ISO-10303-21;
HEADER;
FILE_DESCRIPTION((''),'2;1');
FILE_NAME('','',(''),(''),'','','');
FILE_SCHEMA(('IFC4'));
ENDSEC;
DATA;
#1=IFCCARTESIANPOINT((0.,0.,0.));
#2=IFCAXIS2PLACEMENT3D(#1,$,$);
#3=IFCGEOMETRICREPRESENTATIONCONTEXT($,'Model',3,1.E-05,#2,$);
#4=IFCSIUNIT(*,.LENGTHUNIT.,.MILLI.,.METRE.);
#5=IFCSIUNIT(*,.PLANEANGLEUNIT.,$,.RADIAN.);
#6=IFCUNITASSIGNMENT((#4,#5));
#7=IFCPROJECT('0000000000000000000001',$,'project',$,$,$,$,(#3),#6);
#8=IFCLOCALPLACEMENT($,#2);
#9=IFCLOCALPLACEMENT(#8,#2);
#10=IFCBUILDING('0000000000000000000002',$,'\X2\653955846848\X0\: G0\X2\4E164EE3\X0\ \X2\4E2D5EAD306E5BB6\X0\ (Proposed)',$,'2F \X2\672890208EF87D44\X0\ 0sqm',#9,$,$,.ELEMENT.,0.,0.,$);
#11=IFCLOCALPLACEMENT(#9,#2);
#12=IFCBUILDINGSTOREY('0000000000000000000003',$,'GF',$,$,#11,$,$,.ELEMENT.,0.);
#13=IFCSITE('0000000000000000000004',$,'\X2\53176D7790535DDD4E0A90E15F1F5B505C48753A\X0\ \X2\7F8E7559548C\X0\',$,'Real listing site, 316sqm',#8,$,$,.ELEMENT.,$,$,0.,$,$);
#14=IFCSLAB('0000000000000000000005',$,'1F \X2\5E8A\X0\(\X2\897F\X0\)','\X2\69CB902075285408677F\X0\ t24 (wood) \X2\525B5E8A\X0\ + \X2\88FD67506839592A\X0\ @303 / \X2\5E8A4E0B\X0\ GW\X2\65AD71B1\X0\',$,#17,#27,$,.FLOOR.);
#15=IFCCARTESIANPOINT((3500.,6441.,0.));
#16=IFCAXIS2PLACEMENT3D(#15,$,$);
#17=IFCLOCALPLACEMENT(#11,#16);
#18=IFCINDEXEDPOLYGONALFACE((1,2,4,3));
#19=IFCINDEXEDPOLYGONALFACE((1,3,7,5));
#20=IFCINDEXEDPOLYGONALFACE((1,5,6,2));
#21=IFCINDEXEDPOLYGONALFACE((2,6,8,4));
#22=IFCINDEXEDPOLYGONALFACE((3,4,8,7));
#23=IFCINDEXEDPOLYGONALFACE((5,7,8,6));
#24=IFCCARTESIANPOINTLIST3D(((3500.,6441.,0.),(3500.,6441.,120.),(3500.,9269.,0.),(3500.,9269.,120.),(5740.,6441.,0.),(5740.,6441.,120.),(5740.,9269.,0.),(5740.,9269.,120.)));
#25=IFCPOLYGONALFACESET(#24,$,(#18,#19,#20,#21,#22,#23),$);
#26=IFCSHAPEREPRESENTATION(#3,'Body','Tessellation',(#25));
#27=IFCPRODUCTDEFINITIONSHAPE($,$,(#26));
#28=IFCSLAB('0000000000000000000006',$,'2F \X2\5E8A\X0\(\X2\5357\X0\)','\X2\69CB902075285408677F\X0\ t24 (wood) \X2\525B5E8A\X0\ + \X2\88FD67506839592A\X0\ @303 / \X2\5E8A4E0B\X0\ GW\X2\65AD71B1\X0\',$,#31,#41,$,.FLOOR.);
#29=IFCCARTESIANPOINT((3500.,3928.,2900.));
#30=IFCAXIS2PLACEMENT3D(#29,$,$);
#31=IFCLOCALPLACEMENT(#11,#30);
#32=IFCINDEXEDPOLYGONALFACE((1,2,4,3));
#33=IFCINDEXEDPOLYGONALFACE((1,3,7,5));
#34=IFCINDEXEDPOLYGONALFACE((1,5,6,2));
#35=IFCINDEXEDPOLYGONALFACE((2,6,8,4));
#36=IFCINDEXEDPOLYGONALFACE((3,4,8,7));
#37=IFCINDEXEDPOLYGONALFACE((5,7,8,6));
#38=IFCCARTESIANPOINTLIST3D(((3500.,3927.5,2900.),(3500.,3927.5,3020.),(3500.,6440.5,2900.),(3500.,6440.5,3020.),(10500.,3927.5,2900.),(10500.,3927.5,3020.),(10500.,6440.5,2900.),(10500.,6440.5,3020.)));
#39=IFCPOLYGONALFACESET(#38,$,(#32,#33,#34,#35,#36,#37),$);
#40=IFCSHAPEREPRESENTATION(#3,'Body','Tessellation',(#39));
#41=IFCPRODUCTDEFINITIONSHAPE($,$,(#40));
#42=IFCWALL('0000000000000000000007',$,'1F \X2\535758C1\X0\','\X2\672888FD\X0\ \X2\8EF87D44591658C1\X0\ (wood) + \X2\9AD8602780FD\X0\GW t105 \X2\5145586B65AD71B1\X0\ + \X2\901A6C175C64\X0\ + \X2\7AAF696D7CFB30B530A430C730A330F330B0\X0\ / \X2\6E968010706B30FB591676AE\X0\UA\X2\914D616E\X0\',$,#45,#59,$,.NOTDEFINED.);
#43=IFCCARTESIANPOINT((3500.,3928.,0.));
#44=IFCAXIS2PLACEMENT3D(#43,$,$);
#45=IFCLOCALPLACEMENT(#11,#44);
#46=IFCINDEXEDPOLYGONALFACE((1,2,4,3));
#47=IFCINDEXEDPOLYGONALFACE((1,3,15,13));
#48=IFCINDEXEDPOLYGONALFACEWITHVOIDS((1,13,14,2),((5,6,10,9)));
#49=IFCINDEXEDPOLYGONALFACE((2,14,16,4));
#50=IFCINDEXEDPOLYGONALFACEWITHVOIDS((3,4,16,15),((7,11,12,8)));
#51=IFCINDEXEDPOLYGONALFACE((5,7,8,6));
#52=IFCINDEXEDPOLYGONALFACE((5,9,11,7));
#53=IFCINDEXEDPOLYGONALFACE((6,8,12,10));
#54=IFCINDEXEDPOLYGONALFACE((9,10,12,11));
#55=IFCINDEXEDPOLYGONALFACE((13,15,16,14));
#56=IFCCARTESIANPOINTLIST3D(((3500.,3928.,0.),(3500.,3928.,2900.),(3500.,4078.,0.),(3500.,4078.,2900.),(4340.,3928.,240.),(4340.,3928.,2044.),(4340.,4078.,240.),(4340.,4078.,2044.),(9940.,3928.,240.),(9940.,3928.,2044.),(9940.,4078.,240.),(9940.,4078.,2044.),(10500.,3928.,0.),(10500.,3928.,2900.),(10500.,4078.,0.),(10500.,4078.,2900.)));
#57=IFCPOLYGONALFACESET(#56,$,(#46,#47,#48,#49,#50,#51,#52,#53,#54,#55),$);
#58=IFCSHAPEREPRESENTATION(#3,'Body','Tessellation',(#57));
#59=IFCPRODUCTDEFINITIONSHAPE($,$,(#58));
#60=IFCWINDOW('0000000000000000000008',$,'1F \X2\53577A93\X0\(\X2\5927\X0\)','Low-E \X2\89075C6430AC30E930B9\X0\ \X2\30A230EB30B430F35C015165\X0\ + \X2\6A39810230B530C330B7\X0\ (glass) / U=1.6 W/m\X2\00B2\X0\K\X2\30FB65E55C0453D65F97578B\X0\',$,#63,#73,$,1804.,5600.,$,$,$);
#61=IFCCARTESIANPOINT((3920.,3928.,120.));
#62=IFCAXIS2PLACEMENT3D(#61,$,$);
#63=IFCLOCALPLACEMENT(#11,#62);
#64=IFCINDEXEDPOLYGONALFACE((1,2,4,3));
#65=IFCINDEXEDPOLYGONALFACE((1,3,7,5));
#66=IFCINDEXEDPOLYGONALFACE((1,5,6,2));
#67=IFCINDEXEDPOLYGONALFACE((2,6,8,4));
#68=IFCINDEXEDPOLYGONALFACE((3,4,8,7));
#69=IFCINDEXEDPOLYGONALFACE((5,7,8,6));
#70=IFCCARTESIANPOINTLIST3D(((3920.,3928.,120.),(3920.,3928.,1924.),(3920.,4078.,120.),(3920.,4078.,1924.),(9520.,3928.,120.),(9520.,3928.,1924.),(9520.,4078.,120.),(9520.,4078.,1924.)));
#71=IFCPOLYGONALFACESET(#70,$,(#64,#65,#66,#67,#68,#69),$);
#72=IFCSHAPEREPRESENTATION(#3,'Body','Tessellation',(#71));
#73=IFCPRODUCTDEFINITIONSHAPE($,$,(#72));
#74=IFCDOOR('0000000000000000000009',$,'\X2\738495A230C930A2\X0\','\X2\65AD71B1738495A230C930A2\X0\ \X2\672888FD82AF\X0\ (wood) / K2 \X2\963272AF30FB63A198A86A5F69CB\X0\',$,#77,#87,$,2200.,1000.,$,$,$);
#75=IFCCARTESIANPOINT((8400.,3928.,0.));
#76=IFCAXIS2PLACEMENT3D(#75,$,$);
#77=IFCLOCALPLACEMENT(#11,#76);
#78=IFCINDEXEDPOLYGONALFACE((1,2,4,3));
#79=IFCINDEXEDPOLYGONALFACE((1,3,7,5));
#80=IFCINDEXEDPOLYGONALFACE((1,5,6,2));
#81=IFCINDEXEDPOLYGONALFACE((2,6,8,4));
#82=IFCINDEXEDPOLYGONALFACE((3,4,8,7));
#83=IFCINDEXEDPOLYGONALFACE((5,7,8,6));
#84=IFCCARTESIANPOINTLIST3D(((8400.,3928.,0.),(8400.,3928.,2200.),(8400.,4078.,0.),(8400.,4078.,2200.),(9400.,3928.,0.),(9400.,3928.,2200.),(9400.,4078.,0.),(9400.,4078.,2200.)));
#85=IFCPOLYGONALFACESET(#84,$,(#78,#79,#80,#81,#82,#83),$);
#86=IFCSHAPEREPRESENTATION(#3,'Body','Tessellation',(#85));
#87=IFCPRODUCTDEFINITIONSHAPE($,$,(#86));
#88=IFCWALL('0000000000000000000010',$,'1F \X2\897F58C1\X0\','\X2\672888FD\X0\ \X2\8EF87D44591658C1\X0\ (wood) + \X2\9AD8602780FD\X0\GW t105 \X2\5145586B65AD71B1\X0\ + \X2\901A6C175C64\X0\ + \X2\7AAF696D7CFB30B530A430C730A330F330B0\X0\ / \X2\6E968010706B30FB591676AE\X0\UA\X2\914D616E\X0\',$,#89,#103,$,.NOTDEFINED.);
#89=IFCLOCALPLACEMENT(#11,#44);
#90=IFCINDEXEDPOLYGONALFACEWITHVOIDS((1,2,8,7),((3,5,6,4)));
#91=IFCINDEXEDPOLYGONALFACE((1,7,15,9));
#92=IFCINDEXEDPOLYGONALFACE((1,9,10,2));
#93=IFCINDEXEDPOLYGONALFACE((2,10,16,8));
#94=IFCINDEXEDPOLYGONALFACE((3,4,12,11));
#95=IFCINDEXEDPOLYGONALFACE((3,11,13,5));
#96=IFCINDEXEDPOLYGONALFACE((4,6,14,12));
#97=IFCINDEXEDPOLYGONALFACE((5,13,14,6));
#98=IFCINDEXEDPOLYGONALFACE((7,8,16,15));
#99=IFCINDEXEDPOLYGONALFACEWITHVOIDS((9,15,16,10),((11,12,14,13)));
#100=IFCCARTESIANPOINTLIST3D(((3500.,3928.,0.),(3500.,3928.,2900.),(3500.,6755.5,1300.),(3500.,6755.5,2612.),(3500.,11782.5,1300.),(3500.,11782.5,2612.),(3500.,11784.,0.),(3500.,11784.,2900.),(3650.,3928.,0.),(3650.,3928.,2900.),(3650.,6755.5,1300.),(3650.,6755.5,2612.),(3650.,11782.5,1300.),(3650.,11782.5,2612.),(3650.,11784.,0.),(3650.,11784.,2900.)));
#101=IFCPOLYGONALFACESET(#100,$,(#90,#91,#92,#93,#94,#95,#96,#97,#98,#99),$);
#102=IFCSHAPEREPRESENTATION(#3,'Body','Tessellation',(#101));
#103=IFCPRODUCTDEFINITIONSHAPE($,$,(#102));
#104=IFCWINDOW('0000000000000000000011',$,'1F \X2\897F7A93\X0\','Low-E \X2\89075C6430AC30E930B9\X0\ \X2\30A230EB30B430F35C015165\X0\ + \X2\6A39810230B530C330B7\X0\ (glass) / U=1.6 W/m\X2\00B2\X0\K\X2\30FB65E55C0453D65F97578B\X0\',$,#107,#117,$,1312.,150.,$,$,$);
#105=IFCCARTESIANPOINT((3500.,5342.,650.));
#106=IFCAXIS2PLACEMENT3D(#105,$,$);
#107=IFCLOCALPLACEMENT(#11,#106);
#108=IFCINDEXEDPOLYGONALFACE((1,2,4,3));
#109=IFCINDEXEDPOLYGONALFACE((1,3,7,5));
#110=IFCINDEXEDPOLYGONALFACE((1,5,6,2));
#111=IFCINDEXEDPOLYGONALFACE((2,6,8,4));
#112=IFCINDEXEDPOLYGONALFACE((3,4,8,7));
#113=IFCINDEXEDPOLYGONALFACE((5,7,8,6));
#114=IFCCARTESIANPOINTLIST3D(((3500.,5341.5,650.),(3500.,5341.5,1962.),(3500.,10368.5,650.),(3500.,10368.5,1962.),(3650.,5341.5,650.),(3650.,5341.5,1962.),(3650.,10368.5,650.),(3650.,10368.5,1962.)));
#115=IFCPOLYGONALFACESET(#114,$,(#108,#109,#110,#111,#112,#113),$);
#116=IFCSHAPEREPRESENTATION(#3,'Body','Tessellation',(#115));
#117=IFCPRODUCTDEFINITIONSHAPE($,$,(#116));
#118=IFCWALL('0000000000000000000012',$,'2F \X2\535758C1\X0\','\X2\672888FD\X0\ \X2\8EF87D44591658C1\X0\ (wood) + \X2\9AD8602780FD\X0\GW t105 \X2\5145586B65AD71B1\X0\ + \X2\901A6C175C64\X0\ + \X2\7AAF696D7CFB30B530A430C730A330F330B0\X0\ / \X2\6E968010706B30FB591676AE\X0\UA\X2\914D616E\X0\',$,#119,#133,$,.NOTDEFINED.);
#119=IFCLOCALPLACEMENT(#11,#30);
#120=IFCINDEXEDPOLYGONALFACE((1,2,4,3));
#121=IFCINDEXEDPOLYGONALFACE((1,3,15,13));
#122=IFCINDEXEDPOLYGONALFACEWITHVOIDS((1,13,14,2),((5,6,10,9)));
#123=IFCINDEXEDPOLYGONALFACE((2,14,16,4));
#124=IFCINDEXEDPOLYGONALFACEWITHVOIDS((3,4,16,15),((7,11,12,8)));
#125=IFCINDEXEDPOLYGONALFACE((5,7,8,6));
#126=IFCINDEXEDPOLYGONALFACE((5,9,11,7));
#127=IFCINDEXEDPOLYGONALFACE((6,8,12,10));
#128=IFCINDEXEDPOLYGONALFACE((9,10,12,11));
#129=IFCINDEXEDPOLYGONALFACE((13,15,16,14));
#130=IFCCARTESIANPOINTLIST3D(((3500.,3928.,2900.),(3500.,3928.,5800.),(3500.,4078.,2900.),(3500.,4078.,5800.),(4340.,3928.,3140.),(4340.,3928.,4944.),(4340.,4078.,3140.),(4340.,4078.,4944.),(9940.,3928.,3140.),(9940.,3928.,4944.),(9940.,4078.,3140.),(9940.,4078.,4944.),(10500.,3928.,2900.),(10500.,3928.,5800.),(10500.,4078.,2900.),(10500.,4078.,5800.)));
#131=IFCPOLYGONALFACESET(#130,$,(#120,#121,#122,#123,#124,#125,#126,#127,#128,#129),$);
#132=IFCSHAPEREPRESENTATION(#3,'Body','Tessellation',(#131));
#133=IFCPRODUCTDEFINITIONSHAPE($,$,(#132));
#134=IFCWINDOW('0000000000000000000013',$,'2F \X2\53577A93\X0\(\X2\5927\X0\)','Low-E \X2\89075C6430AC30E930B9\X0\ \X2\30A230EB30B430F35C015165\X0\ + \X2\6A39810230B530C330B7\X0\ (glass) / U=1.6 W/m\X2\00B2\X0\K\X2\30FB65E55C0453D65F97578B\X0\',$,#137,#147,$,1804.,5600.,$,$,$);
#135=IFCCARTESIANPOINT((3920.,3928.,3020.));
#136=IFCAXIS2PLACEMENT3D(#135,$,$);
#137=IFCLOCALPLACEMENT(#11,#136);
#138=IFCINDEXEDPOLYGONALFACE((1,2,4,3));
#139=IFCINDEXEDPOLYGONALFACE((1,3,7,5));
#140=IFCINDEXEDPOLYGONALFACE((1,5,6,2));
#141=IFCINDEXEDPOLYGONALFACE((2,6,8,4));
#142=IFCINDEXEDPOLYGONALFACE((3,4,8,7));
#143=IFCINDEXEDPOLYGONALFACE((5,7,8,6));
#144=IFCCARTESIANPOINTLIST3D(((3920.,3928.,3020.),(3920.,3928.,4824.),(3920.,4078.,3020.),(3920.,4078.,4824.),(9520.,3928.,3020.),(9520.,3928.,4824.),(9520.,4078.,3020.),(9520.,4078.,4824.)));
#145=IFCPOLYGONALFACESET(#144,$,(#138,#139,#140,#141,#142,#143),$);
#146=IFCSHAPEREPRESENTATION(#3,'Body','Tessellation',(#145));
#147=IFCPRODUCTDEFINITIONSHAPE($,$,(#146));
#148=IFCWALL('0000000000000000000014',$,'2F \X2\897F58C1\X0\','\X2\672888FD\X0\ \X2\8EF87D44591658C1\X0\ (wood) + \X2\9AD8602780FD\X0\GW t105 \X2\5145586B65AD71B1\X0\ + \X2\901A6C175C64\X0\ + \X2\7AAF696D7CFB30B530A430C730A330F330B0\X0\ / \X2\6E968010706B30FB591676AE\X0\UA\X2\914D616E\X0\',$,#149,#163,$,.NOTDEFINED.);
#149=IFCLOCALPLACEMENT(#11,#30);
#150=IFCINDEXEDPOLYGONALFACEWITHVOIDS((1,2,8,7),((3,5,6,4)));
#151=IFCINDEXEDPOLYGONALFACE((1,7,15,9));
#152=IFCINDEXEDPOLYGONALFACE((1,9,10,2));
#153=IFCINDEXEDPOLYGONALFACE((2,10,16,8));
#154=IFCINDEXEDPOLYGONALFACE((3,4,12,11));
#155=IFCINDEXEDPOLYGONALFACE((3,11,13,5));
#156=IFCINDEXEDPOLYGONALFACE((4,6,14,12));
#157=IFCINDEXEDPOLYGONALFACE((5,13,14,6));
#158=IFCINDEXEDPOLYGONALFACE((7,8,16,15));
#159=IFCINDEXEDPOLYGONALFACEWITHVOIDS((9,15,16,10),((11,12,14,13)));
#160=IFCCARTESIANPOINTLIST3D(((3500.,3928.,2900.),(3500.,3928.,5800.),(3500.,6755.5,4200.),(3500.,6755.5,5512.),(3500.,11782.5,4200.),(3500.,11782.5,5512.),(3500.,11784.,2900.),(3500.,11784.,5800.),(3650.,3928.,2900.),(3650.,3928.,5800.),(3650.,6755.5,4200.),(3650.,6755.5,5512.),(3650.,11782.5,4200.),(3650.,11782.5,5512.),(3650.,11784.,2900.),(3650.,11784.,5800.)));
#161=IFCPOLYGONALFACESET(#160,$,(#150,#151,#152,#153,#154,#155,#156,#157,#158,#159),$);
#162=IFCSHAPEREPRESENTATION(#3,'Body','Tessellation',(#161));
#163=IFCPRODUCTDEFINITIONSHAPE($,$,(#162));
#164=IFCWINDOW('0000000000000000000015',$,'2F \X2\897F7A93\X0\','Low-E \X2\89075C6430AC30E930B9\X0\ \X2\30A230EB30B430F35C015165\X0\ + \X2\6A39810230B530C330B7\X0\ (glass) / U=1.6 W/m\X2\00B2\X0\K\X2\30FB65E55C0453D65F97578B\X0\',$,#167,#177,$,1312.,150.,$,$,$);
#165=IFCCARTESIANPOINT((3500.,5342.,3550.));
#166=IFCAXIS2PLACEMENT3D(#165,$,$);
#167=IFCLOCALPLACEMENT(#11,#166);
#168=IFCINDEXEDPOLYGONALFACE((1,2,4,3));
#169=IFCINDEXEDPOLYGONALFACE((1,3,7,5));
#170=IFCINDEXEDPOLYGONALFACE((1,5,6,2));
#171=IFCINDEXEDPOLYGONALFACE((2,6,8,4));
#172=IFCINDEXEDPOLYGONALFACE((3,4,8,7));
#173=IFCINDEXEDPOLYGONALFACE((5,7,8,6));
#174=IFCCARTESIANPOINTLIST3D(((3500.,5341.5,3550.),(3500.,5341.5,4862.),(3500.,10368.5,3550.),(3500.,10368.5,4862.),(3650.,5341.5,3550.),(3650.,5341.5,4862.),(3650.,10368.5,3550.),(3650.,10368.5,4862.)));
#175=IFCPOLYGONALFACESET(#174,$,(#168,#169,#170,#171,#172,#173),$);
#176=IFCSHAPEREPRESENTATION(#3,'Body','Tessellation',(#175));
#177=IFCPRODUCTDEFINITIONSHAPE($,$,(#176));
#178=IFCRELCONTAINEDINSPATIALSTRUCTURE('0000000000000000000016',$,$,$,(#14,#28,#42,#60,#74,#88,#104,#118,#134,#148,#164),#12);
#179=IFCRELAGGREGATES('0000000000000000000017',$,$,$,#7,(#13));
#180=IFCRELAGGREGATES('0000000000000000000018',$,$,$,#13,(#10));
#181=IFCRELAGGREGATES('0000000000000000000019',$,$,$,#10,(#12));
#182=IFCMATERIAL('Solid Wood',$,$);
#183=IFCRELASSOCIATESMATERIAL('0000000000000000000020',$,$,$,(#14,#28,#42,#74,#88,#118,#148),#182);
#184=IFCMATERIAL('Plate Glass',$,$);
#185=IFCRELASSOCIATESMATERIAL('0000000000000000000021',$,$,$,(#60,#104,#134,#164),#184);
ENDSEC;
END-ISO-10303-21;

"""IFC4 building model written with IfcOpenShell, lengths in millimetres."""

from ifc_helpers import new_model, si_unit, frame, frame_2d, origin, place, context, project, spatial, rectangle, extrude, material, element, fill, save


model = new_model("IFC4")

# Units and contexts
model_context = context("Model", 3, precision=1e-05, world=origin())
ifc_project = project(units=[si_unit("LENGTHUNIT", "METRE", prefix="MILLI"), si_unit("PLANEANGLEUNIT", "RADIAN")], contexts=[model_context])

# Site, building, storey
site_placement = place(None, origin())
site = spatial("IfcSite", under=ifc_project, at=site_placement, Name="北海道川上郡弟子屈町 美留和", ObjectType="Real listing site, 316sqm", CompositionType="ELEMENT", RefElevation=0.0)
building_placement = place(site_placement, origin())
building = spatial("IfcBuilding", under=site, at=building_placement, Name="改善案: G0世代 中庭の家 (Proposed)", ObjectType="2F 木造軸組 0sqm", CompositionType="ELEMENT", ElevationOfRefHeight=0.0, ElevationOfTerrain=0.0)
storey_placement = place(building_placement, origin())
storey = spatial("IfcBuildingStorey", under=building, at=storey_placement, Name="GF", CompositionType="ELEMENT", Elevation=0.0)

# Slabs
ifc_material_1 = material(Name="Solid Wood")
slab_1_placement = place(storey_placement, frame((3500.0, 6441.0, 0.0)))
element("IfcSlab", 1, at=slab_1_placement, inside=storey, material=ifc_material_1, Name="1F 床(西)", Description="構造用合板 t24 (wood) 剛床 + 製材根太 @303 / 床下 GW断熱", PredefinedType="FLOOR", context=model_context, shape_type="SweptSolid", body=[
    extrude(rectangle(XDim=2240.0, YDim=2828.0, at=frame_2d((1120.0, 1414.0))), frame((3500.0, 6441.0, 0.0)), (0.0, 0.0, 1.0), 120.0),
])
slab_2_placement = place(storey_placement, frame((3500.0, 3928.0, 2900.0)))
element("IfcSlab", 2, at=slab_2_placement, inside=storey, material=ifc_material_1, Name="2F 床(南)", Description="構造用合板 t24 (wood) 剛床 + 製材根太 @303 / 床下 GW断熱", PredefinedType="FLOOR", context=model_context, shape_type="SweptSolid", body=[
    extrude(rectangle(XDim=7000.0, YDim=2513.0, at=frame_2d((3500.0, 1256.0))), frame((3500.0, 3928.0, 2900.0)), (0.0, 0.0, 1.0), 120.0),
])

# Wall, openings, window, door
wall_1_placement = place(storey_placement, frame((3500.0, 3928.0, 0.0)))
wall_1 = element("IfcWall", 3, at=wall_1_placement, inside=storey, material=ifc_material_1, Name="1F 南壁", Description="木製 軸組外壁 (wood) + 高性能GW t105 充填断熱 + 通気層 + 窯業系サイディング / 準耐火・外皮UA配慮", PredefinedType="NOTDEFINED", context=model_context, shape_type="SweptSolid", body=[
    extrude(rectangle(XDim=7000.0, YDim=150.0, at=frame_2d((3500.0, 75.0))), frame((3500.0, 3928.0, 0.0)), (0.0, 0.0, 1.0), 2900.0),
])
opening_1_placement = place(storey_placement, frame((3920.0, 3928.0, 120.0)))
opening_1 = element("IfcOpeningElement", 4, at=opening_1_placement, cuts=wall_1, PredefinedType="NOTDEFINED", context=model_context, shape_type="SweptSolid", body=[
    extrude(rectangle(XDim=5600.0, YDim=150.0, at=frame_2d((2800.0, 75.0))), frame((3920.0, 3928.0, 120.0)), (0.0, 0.0, 1.0), 1804.0),
])
opening_2_placement = place(storey_placement, frame((8400.0, 3928.0, 0.0)))
opening_2 = element("IfcOpeningElement", 5, at=opening_2_placement, cuts=wall_1, PredefinedType="NOTDEFINED", context=model_context, shape_type="SweptSolid", body=[
    extrude(rectangle(XDim=1000.0, YDim=150.0, at=frame_2d((500.0, 75.0))), frame((8400.0, 3928.0, 0.0)), (0.0, 0.0, 1.0), 2200.0),
])
ifc_material_2 = material(Name="Plate Glass")
window_1_placement = place(storey_placement, frame((3920.0, 3928.0, 120.0)))
window_1 = element("IfcWindow", 6, at=window_1_placement, inside=storey, material=ifc_material_2, Name="1F 南窓(大)", Description="Low-E 複層ガラス アルゴン封入 + 樹脂サッシ (glass) / U=1.6 W/m²K・日射取得型", OverallHeight=1804.0, OverallWidth=5600.0, context=model_context, shape_type="SweptSolid", body=[
    extrude(rectangle(XDim=5600.0, YDim=150.0, at=frame_2d((2800.0, 75.0))), frame((3920.0, 3928.0, 120.0)), (0.0, 0.0, 1.0), 1804.0),
])
fill(opening_1, window_1)
door_placement = place(storey_placement, frame((8400.0, 3928.0, 0.0)))
door = element("IfcDoor", 7, at=door_placement, inside=storey, material=ifc_material_1, Name="玄関ドア", Description="断熱玄関ドア 木製芯 (wood) / K2 防犯・採風機構", OverallHeight=2200.0, OverallWidth=1000.0, context=model_context, shape_type="SweptSolid", body=[
    extrude(rectangle(XDim=1000.0, YDim=150.0, at=frame_2d((500.0, 75.0))), frame((8400.0, 3928.0, 0.0)), (0.0, 0.0, 1.0), 2200.0),
])
fill(opening_2, door)

# Walls, openings, windows
wall_2_placement = place(storey_placement, frame((3500.0, 3928.0, 0.0)))
wall_2 = element("IfcWall", 8, at=wall_2_placement, inside=storey, material=ifc_material_1, Name="1F 西壁", Description="木製 軸組外壁 (wood) + 高性能GW t105 充填断熱 + 通気層 + 窯業系サイディング / 準耐火・外皮UA配慮", PredefinedType="NOTDEFINED", context=model_context, shape_type="SweptSolid", body=[
    extrude(rectangle(XDim=150.0, YDim=7856.0, at=frame_2d((75.0, 3928.0))), frame((3500.0, 3928.0, 0.0)), (0.0, 0.0, 1.0), 2900.0),
])
opening_3_placement = place(storey_placement, frame((3500.0, 5342.0, 650.0)))
opening_3 = element("IfcOpeningElement", 9, at=opening_3_placement, cuts=wall_2, PredefinedType="NOTDEFINED", context=model_context, shape_type="SweptSolid", body=[
    extrude(rectangle(XDim=150.0, YDim=5027.0, at=frame_2d((75.0, 2513.0))), frame((3500.0, 5342.0, 650.0)), (0.0, 0.0, 1.0), 1312.0),
])
window_2_placement = place(storey_placement, frame((3500.0, 5342.0, 650.0)))
window_2 = element("IfcWindow", 10, at=window_2_placement, inside=storey, material=ifc_material_2, Name="1F 西窓", Description="Low-E 複層ガラス アルゴン封入 + 樹脂サッシ (glass) / U=1.6 W/m²K・日射取得型", OverallHeight=1312.0, OverallWidth=150.0, context=model_context, shape_type="SweptSolid", body=[
    extrude(rectangle(XDim=150.0, YDim=5027.0, at=frame_2d((75.0, 2513.0))), frame((3500.0, 5342.0, 650.0)), (0.0, 0.0, 1.0), 1312.0),
])
fill(opening_3, window_2)
wall_3_placement = place(storey_placement, frame((3500.0, 3928.0, 2900.0)))
wall_3 = element("IfcWall", 11, at=wall_3_placement, inside=storey, material=ifc_material_1, Name="2F 南壁", Description="木製 軸組外壁 (wood) + 高性能GW t105 充填断熱 + 通気層 + 窯業系サイディング / 準耐火・外皮UA配慮", PredefinedType="NOTDEFINED", context=model_context, shape_type="SweptSolid", body=[
    extrude(rectangle(XDim=7000.0, YDim=150.0, at=frame_2d((3500.0, 75.0))), frame((3500.0, 3928.0, 2900.0)), (0.0, 0.0, 1.0), 2900.0),
])
opening_4_placement = place(storey_placement, frame((3920.0, 3928.0, 3020.0)))
opening_4 = element("IfcOpeningElement", 12, at=opening_4_placement, cuts=wall_3, PredefinedType="NOTDEFINED", context=model_context, shape_type="SweptSolid", body=[
    extrude(rectangle(XDim=5600.0, YDim=150.0, at=frame_2d((2800.0, 75.0))), frame((3920.0, 3928.0, 3020.0)), (0.0, 0.0, 1.0), 1804.0),
])
window_3_placement = place(storey_placement, frame((3920.0, 3928.0, 3020.0)))
window_3 = element("IfcWindow", 13, at=window_3_placement, inside=storey, material=ifc_material_2, Name="2F 南窓(大)", Description="Low-E 複層ガラス アルゴン封入 + 樹脂サッシ (glass) / U=1.6 W/m²K・日射取得型", OverallHeight=1804.0, OverallWidth=5600.0, context=model_context, shape_type="SweptSolid", body=[
    extrude(rectangle(XDim=5600.0, YDim=150.0, at=frame_2d((2800.0, 75.0))), frame((3920.0, 3928.0, 3020.0)), (0.0, 0.0, 1.0), 1804.0),
])
fill(opening_4, window_3)
wall_4_placement = place(storey_placement, frame((3500.0, 3928.0, 2900.0)))
wall_4 = element("IfcWall", 14, at=wall_4_placement, inside=storey, material=ifc_material_1, Name="2F 西壁", Description="木製 軸組外壁 (wood) + 高性能GW t105 充填断熱 + 通気層 + 窯業系サイディング / 準耐火・外皮UA配慮", PredefinedType="NOTDEFINED", context=model_context, shape_type="SweptSolid", body=[
    extrude(rectangle(XDim=150.0, YDim=7856.0, at=frame_2d((75.0, 3928.0))), frame((3500.0, 3928.0, 2900.0)), (0.0, 0.0, 1.0), 2900.0),
])
opening_5_placement = place(storey_placement, frame((3500.0, 5342.0, 3550.0)))
opening_5 = element("IfcOpeningElement", 15, at=opening_5_placement, cuts=wall_4, PredefinedType="NOTDEFINED", context=model_context, shape_type="SweptSolid", body=[
    extrude(rectangle(XDim=150.0, YDim=5027.0, at=frame_2d((75.0, 2513.0))), frame((3500.0, 5342.0, 3550.0)), (0.0, 0.0, 1.0), 1312.0),
])
window_4_placement = place(storey_placement, frame((3500.0, 5342.0, 3550.0)))
window_4 = element("IfcWindow", 16, at=window_4_placement, inside=storey, material=ifc_material_2, Name="2F 西窓", Description="Low-E 複層ガラス アルゴン封入 + 樹脂サッシ (glass) / U=1.6 W/m²K・日射取得型", OverallHeight=1312.0, OverallWidth=150.0, context=model_context, shape_type="SweptSolid", body=[
    extrude(rectangle(XDim=150.0, YDim=5027.0, at=frame_2d((75.0, 2513.0))), frame((3500.0, 5342.0, 3550.0)), (0.0, 0.0, 1.0), 1312.0),
])
fill(opening_5, window_4)

save(model, "model.ifc")
